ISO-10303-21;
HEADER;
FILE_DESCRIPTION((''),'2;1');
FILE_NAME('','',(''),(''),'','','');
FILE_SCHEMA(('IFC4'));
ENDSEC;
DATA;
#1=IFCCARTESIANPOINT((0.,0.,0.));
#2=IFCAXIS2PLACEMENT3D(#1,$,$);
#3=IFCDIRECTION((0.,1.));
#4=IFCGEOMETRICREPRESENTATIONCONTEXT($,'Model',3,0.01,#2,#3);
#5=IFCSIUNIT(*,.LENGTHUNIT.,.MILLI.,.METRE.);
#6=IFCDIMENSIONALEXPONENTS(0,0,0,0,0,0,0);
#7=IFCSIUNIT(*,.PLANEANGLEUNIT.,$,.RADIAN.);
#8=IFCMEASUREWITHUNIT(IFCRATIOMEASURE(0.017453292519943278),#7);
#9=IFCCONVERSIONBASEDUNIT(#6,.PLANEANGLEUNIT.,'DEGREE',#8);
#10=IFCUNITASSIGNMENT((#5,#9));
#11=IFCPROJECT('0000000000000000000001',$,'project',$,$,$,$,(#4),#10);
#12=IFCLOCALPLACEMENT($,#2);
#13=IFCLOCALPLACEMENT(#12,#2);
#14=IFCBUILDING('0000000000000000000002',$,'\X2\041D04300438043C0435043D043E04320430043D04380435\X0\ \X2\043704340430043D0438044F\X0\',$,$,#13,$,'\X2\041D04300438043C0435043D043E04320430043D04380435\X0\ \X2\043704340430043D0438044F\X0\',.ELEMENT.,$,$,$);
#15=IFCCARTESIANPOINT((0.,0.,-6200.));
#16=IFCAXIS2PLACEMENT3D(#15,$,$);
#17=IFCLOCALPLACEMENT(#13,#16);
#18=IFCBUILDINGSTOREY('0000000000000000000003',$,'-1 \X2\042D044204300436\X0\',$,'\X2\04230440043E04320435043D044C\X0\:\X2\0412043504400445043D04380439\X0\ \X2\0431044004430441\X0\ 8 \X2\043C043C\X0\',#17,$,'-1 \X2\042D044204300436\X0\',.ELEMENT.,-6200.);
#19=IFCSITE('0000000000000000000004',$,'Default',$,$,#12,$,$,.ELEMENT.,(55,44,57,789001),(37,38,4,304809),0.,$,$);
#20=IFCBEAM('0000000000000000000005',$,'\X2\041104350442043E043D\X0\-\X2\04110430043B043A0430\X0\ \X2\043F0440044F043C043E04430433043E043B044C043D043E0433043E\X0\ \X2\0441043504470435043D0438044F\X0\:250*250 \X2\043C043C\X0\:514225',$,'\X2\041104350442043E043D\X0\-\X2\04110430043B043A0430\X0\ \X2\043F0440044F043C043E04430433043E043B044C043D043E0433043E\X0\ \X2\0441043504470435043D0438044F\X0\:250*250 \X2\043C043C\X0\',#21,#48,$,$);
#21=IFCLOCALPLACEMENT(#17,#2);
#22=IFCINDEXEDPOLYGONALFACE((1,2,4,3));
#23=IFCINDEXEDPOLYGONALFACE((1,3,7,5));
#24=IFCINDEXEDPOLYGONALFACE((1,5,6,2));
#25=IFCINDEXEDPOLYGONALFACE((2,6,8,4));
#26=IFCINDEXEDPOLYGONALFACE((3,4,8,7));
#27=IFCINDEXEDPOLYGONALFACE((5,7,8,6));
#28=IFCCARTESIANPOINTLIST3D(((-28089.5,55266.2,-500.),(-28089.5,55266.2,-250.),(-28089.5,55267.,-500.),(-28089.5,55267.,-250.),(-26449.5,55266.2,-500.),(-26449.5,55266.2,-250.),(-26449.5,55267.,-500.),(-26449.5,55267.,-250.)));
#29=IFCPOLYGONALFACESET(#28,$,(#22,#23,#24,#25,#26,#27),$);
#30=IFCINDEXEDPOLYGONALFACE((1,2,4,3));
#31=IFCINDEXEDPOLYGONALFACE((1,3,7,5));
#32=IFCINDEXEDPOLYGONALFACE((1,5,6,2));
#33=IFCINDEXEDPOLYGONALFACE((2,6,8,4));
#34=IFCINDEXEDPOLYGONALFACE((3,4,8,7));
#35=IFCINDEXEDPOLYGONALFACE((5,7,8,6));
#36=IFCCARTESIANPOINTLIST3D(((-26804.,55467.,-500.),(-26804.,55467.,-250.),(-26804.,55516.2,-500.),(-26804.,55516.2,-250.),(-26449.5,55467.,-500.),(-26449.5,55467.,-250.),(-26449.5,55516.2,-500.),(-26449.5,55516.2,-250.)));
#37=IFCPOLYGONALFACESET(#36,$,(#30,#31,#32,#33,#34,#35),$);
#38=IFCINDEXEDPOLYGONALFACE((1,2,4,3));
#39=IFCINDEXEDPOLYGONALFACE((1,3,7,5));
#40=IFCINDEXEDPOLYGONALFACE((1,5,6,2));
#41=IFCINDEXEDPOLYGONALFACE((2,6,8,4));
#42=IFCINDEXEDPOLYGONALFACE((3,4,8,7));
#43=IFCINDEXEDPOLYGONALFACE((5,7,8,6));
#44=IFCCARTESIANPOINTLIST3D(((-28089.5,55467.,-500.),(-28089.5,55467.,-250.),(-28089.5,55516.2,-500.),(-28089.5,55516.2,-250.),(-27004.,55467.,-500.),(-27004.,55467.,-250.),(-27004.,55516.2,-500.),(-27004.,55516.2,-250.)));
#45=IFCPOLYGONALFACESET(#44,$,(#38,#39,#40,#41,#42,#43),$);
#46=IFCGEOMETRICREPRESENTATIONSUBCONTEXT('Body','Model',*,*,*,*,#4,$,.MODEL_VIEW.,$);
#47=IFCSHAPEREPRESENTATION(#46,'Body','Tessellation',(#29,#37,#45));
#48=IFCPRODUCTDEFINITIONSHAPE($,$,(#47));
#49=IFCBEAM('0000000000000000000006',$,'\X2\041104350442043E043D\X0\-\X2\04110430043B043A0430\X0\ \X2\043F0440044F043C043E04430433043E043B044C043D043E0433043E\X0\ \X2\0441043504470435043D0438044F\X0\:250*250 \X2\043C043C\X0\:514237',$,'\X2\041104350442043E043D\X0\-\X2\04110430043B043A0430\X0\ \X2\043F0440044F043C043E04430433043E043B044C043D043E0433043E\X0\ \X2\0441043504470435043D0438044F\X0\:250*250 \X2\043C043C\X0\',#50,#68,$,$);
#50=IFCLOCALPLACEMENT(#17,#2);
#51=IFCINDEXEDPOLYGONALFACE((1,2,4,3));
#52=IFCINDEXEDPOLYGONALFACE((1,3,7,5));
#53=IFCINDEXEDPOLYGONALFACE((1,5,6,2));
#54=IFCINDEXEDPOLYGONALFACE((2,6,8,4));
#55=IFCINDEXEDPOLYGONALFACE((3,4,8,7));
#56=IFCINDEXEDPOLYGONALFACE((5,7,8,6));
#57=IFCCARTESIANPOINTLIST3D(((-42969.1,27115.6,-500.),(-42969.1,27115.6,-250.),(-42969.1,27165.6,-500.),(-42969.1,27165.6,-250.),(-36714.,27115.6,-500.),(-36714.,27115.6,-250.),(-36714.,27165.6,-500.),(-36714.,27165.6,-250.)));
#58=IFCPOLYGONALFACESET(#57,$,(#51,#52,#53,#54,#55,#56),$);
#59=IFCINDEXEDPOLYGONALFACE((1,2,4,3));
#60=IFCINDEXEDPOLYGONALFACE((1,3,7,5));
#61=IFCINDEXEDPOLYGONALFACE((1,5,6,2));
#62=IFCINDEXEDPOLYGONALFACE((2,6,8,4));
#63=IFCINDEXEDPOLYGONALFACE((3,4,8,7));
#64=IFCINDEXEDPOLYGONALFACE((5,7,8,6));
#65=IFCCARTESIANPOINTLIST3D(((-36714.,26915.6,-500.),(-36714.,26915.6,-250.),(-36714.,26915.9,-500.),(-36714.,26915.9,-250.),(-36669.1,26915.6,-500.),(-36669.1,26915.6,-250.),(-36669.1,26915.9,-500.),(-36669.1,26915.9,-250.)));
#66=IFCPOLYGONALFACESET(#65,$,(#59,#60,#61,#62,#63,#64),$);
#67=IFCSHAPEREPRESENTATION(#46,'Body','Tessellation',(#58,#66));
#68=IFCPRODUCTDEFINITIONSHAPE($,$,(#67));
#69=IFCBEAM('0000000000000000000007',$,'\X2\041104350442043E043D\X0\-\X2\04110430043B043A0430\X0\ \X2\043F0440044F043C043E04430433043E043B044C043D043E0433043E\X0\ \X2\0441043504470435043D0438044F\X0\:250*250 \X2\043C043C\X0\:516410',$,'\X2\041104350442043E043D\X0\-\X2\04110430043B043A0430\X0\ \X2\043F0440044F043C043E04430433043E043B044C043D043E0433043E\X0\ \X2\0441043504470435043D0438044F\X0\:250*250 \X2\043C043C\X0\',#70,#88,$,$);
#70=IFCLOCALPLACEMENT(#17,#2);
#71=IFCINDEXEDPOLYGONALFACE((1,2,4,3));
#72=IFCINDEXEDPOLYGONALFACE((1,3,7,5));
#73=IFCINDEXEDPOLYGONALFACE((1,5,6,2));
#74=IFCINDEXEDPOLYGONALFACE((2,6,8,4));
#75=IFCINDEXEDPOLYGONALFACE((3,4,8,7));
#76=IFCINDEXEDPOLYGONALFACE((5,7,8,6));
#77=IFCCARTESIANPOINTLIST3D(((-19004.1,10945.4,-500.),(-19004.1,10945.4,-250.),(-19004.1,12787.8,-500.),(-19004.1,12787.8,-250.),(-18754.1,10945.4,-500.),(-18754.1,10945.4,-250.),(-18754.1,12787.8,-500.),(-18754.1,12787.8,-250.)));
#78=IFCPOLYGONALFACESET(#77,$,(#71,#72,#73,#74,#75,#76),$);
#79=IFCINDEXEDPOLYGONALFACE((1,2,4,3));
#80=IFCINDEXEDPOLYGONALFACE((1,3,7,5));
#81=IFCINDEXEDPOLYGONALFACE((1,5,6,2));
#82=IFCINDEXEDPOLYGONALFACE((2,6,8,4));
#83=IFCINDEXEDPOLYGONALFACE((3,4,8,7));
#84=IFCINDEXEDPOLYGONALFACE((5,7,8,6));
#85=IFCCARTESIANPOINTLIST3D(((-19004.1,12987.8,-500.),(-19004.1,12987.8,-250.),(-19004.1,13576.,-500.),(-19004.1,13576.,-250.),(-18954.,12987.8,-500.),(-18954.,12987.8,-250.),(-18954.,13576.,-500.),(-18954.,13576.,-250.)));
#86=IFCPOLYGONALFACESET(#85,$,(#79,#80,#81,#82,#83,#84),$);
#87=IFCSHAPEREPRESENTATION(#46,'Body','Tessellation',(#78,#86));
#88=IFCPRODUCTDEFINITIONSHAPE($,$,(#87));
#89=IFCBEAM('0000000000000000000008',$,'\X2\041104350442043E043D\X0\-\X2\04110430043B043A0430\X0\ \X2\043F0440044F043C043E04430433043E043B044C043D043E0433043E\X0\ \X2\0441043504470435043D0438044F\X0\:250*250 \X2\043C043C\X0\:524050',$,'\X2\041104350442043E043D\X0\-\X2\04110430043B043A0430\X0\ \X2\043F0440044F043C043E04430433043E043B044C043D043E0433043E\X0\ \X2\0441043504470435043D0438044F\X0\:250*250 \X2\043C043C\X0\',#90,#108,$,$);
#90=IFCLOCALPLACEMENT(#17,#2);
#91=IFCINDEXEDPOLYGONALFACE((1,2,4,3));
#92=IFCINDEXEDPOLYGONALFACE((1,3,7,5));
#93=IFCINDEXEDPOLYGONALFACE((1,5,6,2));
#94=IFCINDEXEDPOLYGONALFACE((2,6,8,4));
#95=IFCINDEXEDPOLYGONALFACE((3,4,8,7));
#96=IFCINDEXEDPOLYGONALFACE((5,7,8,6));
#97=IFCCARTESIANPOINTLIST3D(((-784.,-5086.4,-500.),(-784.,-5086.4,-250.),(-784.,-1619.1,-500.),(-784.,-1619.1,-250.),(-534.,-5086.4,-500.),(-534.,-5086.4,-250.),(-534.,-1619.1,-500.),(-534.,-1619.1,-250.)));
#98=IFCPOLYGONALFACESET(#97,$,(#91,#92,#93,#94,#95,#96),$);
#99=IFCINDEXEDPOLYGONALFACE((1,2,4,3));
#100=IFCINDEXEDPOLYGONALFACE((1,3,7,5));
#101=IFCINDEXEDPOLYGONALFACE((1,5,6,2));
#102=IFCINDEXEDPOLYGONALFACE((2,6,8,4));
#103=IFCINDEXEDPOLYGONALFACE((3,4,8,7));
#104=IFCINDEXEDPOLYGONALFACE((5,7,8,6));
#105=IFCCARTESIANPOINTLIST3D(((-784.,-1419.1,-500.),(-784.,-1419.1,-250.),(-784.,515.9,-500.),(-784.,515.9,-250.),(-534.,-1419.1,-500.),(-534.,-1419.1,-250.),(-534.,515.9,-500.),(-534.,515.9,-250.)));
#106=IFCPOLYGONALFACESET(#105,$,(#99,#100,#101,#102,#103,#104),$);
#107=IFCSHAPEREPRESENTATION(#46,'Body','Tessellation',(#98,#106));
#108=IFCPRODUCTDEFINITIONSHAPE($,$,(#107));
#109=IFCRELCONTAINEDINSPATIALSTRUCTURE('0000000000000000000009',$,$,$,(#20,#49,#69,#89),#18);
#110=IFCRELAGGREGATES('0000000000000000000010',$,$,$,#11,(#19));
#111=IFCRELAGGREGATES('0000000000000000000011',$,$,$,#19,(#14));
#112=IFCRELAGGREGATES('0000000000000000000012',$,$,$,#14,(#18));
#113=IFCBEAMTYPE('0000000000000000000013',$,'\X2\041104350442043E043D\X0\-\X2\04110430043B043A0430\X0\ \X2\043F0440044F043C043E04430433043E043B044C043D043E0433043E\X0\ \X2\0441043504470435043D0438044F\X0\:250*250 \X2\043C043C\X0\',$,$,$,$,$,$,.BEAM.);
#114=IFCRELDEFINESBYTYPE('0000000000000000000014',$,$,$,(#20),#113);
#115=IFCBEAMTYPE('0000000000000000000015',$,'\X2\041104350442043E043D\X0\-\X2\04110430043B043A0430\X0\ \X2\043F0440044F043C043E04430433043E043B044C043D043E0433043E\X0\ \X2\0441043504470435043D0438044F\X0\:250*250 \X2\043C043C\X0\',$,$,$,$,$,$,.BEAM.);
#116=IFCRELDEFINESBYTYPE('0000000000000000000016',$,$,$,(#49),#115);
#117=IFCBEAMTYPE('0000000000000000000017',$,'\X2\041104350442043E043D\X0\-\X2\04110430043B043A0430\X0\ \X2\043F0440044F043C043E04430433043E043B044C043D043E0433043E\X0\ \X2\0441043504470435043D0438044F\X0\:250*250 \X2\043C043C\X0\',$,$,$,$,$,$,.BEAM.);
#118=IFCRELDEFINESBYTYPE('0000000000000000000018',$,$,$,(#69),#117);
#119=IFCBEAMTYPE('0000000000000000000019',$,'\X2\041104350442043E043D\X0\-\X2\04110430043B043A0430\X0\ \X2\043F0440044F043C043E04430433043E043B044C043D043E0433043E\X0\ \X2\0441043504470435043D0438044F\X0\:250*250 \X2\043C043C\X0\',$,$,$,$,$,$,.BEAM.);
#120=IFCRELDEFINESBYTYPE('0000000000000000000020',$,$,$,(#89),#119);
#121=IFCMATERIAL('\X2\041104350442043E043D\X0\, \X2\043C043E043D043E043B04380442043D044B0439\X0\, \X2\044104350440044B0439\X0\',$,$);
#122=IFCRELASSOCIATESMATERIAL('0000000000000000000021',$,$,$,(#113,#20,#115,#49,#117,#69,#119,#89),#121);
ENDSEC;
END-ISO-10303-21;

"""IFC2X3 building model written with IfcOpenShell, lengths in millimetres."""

from ifc_helpers import new_model, entity, si_unit, converted_unit, direction, frame, frame_2d, origin, origin_2d_with_axis, place, context, subcontext, project, spatial, rectangle, extrude, source, transform, mapped, material, type_object, type_shapes, element, save


model = new_model("IFC2X3")

# Units and contexts
model_context = context("Model", 3, precision=0.01, world=origin(), true_north=direction((0.0, 1.0)))
body_context = subcontext(model_context, "Body", "Model", "MODEL_VIEW")
ifc_project = project(units=[si_unit("LENGTHUNIT", "METRE", prefix="MILLI"), converted_unit("PLANEANGLEUNIT", "DEGREE", entity("IfcRatioMeasure", 0.017453292519943278), si_unit("PLANEANGLEUNIT", "RADIAN"), dimensions=[0, 0, 0, 0, 0, 0, 0])], contexts=[model_context])

# Site, building, storey
site_placement = place(None, origin())
site = spatial("IfcSite", under=ifc_project, at=site_placement, Name="Default", CompositionType="ELEMENT", RefLatitude=(55, 44, 57, 789001), RefLongitude=(37, 38, 4, 304809), RefElevation=0.0)
building_placement = place(site_placement, origin())
building = spatial("IfcBuilding", under=site, at=building_placement, Name="Наименование здания", LongName="Наименование здания", CompositionType="ELEMENT")
storey_placement = place(building_placement, frame((0.0, 0.0, -6200.0)))
storey = spatial("IfcBuildingStorey", under=building, at=storey_placement, Name="-1 Этаж", ObjectType="Уровень:Верхний брус 8 мм", LongName="-1 Этаж", CompositionType="ELEMENT", Elevation=-6200.0)

# Beams
ifc_material_1 = material(Name="Бетон, монолитный, серый")
beam_type_1 = type_object("IfcBeamType", Name="Бетон-Балка прямоугольного сечения:250*250 мм", PredefinedType="BEAM", material=ifc_material_1)
shared_shape_1 = source(origin(), body_context, "Body", "SweptSolid", [
    extrude(rectangle(XDim=250.0, YDim=0.9, at=origin_2d_with_axis()), frame((-26449.5, 55266.6, -6575.0), z_axis=(-1.0, 0.0, 0.0), x_axis=(0.0, 0.0, -1.0)), (0.0, 0.0, 1.0), 1640.0),
    extrude(rectangle(XDim=250.0, YDim=49.1, at=frame_2d((0.0, 0.0), x_axis=(1.0, 0.0))), frame((-26449.5, 55491.6, -6575.0), z_axis=(-1.0, 0.0, 0.0), x_axis=(0.0, 0.0, -1.0)), (0.0, 0.0, 1.0), 354.5),
    extrude(rectangle(XDim=250.0, YDim=49.1, at=frame_2d((0.0, 0.0), x_axis=(1.0, 0.0))), frame((-27004.0, 55491.6, -6575.0), z_axis=(-1.0, 0.0, 0.0), x_axis=(0.0, 0.0, -1.0)), (0.0, 0.0, 1.0), 1085.5),
])
type_shapes(beam_type_1, [shared_shape_1])
beam_1_placement = place(storey_placement, frame((0.0, 0.0, 6200.0)))
element("IfcBeam", 1, at=beam_1_placement, inside=storey, type_object=beam_type_1, material=ifc_material_1, Name="Бетон-Балка прямоугольного сечения:250*250 мм:514225", ObjectType="Бетон-Балка прямоугольного сечения:250*250 мм", context=body_context, shape_type="MappedRepresentation", body=[
    mapped(shared_shape_1, transform((0.0, 0.0, 0.0), scale=1.0)),
])
beam_type_2 = type_object("IfcBeamType", Name="Бетон-Балка прямоугольного сечения:250*250 мм", PredefinedType="BEAM", material=ifc_material_1)
shared_shape_2 = source(origin(), body_context, "Body", "SweptSolid", [
    extrude(rectangle(XDim=250.0, YDim=50.0, at=frame_2d((0.0, 0.0), x_axis=(1.0, 0.0))), frame((-36714.0, 27140.6, -6575.0), z_axis=(-1.0, 0.0, 0.0), x_axis=(0.0, 0.0, -1.0)), (0.0, 0.0, 1.0), 6255.1),
    extrude(rectangle(XDim=250.0, YDim=0.3, at=frame_2d((0.0, 0.0), x_axis=(1.0, 0.0))), frame((-36669.1, 26915.8, -6575.0), z_axis=(1.0, 0.0, 0.0), x_axis=(0.0, 0.0, -1.0)), (0.0, 0.0, -1.0), 44.9),
])
type_shapes(beam_type_2, [shared_shape_2])
beam_2_placement = place(storey_placement, frame((0.0, 0.0, 6200.0)))
element("IfcBeam", 2, at=beam_2_placement, inside=storey, type_object=beam_type_2, material=ifc_material_1, Name="Бетон-Балка прямоугольного сечения:250*250 мм:514237", ObjectType="Бетон-Балка прямоугольного сечения:250*250 мм", context=body_context, shape_type="MappedRepresentation", body=[
    mapped(shared_shape_2, transform((0.0, 0.0, 0.0), scale=1.0)),
])
beam_type_3 = type_object("IfcBeamType", Name="Бетон-Балка прямоугольного сечения:250*250 мм", PredefinedType="BEAM", material=ifc_material_1)
shared_shape_3 = source(origin(), body_context, "Body", "SweptSolid", [
    extrude(rectangle(XDim=250.0, YDim=250.0, at=frame_2d((0.0, 0.0), x_axis=(0.0, 1.0))), frame((-18879.1, 12787.8, -6575.0), z_axis=(0.0, -1.0, 0.0), x_axis=(-1.0, 0.0, 0.0)), (0.0, 0.0, 1.0), 1842.4),
    extrude(rectangle(XDim=250.0, YDim=50.2, at=frame_2d((0.0, 0.0), x_axis=(0.0, 1.0))), frame((-18979.1, 13576.0, -6575.0), z_axis=(0.0, -1.0, 0.0), x_axis=(-1.0, 0.0, 0.0)), (0.0, 0.0, 1.0), 588.1),
])
type_shapes(beam_type_3, [shared_shape_3])
beam_3_placement = place(storey_placement, frame((0.0, 0.0, 6200.0)))
element("IfcBeam", 3, at=beam_3_placement, inside=storey, type_object=beam_type_3, material=ifc_material_1, Name="Бетон-Балка прямоугольного сечения:250*250 мм:516410", ObjectType="Бетон-Балка прямоугольного сечения:250*250 мм", context=body_context, shape_type="MappedRepresentation", body=[
    mapped(shared_shape_3, transform((0.0, 0.0, 0.0), scale=1.0)),
])
beam_type_4 = type_object("IfcBeamType", Name="Бетон-Балка прямоугольного сечения:250*250 мм", PredefinedType="BEAM", material=ifc_material_1)
shared_shape_4 = source(origin(), body_context, "Body", "SweptSolid", [
    extrude(rectangle(XDim=250.0, YDim=250.0, at=frame_2d((0.0, 0.0), x_axis=(0.0, 1.0))), frame((-659.0, -1619.1, -6575.0), z_axis=(0.0, -1.0, 0.0), x_axis=(-1.0, 0.0, 0.0)), (0.0, 0.0, 1.0), 3467.3),
    extrude(rectangle(XDim=250.0, YDim=250.0, at=frame_2d((0.0, 0.0), x_axis=(0.0, 1.0))), frame((-659.0, 515.9, -6575.0), z_axis=(0.0, -1.0, 0.0), x_axis=(-1.0, 0.0, 0.0)), (0.0, 0.0, 1.0), 1935.0),
])
type_shapes(beam_type_4, [shared_shape_4])
beam_4_placement = place(storey_placement, frame((0.0, 0.0, 6200.0)))
element("IfcBeam", 4, at=beam_4_placement, inside=storey, type_object=beam_type_4, material=ifc_material_1, Name="Бетон-Балка прямоугольного сечения:250*250 мм:524050", ObjectType="Бетон-Балка прямоугольного сечения:250*250 мм", context=body_context, shape_type="MappedRepresentation", body=[
    mapped(shared_shape_4, transform((0.0, 0.0, 0.0), scale=1.0)),
])

save(model, "model.ifc")
